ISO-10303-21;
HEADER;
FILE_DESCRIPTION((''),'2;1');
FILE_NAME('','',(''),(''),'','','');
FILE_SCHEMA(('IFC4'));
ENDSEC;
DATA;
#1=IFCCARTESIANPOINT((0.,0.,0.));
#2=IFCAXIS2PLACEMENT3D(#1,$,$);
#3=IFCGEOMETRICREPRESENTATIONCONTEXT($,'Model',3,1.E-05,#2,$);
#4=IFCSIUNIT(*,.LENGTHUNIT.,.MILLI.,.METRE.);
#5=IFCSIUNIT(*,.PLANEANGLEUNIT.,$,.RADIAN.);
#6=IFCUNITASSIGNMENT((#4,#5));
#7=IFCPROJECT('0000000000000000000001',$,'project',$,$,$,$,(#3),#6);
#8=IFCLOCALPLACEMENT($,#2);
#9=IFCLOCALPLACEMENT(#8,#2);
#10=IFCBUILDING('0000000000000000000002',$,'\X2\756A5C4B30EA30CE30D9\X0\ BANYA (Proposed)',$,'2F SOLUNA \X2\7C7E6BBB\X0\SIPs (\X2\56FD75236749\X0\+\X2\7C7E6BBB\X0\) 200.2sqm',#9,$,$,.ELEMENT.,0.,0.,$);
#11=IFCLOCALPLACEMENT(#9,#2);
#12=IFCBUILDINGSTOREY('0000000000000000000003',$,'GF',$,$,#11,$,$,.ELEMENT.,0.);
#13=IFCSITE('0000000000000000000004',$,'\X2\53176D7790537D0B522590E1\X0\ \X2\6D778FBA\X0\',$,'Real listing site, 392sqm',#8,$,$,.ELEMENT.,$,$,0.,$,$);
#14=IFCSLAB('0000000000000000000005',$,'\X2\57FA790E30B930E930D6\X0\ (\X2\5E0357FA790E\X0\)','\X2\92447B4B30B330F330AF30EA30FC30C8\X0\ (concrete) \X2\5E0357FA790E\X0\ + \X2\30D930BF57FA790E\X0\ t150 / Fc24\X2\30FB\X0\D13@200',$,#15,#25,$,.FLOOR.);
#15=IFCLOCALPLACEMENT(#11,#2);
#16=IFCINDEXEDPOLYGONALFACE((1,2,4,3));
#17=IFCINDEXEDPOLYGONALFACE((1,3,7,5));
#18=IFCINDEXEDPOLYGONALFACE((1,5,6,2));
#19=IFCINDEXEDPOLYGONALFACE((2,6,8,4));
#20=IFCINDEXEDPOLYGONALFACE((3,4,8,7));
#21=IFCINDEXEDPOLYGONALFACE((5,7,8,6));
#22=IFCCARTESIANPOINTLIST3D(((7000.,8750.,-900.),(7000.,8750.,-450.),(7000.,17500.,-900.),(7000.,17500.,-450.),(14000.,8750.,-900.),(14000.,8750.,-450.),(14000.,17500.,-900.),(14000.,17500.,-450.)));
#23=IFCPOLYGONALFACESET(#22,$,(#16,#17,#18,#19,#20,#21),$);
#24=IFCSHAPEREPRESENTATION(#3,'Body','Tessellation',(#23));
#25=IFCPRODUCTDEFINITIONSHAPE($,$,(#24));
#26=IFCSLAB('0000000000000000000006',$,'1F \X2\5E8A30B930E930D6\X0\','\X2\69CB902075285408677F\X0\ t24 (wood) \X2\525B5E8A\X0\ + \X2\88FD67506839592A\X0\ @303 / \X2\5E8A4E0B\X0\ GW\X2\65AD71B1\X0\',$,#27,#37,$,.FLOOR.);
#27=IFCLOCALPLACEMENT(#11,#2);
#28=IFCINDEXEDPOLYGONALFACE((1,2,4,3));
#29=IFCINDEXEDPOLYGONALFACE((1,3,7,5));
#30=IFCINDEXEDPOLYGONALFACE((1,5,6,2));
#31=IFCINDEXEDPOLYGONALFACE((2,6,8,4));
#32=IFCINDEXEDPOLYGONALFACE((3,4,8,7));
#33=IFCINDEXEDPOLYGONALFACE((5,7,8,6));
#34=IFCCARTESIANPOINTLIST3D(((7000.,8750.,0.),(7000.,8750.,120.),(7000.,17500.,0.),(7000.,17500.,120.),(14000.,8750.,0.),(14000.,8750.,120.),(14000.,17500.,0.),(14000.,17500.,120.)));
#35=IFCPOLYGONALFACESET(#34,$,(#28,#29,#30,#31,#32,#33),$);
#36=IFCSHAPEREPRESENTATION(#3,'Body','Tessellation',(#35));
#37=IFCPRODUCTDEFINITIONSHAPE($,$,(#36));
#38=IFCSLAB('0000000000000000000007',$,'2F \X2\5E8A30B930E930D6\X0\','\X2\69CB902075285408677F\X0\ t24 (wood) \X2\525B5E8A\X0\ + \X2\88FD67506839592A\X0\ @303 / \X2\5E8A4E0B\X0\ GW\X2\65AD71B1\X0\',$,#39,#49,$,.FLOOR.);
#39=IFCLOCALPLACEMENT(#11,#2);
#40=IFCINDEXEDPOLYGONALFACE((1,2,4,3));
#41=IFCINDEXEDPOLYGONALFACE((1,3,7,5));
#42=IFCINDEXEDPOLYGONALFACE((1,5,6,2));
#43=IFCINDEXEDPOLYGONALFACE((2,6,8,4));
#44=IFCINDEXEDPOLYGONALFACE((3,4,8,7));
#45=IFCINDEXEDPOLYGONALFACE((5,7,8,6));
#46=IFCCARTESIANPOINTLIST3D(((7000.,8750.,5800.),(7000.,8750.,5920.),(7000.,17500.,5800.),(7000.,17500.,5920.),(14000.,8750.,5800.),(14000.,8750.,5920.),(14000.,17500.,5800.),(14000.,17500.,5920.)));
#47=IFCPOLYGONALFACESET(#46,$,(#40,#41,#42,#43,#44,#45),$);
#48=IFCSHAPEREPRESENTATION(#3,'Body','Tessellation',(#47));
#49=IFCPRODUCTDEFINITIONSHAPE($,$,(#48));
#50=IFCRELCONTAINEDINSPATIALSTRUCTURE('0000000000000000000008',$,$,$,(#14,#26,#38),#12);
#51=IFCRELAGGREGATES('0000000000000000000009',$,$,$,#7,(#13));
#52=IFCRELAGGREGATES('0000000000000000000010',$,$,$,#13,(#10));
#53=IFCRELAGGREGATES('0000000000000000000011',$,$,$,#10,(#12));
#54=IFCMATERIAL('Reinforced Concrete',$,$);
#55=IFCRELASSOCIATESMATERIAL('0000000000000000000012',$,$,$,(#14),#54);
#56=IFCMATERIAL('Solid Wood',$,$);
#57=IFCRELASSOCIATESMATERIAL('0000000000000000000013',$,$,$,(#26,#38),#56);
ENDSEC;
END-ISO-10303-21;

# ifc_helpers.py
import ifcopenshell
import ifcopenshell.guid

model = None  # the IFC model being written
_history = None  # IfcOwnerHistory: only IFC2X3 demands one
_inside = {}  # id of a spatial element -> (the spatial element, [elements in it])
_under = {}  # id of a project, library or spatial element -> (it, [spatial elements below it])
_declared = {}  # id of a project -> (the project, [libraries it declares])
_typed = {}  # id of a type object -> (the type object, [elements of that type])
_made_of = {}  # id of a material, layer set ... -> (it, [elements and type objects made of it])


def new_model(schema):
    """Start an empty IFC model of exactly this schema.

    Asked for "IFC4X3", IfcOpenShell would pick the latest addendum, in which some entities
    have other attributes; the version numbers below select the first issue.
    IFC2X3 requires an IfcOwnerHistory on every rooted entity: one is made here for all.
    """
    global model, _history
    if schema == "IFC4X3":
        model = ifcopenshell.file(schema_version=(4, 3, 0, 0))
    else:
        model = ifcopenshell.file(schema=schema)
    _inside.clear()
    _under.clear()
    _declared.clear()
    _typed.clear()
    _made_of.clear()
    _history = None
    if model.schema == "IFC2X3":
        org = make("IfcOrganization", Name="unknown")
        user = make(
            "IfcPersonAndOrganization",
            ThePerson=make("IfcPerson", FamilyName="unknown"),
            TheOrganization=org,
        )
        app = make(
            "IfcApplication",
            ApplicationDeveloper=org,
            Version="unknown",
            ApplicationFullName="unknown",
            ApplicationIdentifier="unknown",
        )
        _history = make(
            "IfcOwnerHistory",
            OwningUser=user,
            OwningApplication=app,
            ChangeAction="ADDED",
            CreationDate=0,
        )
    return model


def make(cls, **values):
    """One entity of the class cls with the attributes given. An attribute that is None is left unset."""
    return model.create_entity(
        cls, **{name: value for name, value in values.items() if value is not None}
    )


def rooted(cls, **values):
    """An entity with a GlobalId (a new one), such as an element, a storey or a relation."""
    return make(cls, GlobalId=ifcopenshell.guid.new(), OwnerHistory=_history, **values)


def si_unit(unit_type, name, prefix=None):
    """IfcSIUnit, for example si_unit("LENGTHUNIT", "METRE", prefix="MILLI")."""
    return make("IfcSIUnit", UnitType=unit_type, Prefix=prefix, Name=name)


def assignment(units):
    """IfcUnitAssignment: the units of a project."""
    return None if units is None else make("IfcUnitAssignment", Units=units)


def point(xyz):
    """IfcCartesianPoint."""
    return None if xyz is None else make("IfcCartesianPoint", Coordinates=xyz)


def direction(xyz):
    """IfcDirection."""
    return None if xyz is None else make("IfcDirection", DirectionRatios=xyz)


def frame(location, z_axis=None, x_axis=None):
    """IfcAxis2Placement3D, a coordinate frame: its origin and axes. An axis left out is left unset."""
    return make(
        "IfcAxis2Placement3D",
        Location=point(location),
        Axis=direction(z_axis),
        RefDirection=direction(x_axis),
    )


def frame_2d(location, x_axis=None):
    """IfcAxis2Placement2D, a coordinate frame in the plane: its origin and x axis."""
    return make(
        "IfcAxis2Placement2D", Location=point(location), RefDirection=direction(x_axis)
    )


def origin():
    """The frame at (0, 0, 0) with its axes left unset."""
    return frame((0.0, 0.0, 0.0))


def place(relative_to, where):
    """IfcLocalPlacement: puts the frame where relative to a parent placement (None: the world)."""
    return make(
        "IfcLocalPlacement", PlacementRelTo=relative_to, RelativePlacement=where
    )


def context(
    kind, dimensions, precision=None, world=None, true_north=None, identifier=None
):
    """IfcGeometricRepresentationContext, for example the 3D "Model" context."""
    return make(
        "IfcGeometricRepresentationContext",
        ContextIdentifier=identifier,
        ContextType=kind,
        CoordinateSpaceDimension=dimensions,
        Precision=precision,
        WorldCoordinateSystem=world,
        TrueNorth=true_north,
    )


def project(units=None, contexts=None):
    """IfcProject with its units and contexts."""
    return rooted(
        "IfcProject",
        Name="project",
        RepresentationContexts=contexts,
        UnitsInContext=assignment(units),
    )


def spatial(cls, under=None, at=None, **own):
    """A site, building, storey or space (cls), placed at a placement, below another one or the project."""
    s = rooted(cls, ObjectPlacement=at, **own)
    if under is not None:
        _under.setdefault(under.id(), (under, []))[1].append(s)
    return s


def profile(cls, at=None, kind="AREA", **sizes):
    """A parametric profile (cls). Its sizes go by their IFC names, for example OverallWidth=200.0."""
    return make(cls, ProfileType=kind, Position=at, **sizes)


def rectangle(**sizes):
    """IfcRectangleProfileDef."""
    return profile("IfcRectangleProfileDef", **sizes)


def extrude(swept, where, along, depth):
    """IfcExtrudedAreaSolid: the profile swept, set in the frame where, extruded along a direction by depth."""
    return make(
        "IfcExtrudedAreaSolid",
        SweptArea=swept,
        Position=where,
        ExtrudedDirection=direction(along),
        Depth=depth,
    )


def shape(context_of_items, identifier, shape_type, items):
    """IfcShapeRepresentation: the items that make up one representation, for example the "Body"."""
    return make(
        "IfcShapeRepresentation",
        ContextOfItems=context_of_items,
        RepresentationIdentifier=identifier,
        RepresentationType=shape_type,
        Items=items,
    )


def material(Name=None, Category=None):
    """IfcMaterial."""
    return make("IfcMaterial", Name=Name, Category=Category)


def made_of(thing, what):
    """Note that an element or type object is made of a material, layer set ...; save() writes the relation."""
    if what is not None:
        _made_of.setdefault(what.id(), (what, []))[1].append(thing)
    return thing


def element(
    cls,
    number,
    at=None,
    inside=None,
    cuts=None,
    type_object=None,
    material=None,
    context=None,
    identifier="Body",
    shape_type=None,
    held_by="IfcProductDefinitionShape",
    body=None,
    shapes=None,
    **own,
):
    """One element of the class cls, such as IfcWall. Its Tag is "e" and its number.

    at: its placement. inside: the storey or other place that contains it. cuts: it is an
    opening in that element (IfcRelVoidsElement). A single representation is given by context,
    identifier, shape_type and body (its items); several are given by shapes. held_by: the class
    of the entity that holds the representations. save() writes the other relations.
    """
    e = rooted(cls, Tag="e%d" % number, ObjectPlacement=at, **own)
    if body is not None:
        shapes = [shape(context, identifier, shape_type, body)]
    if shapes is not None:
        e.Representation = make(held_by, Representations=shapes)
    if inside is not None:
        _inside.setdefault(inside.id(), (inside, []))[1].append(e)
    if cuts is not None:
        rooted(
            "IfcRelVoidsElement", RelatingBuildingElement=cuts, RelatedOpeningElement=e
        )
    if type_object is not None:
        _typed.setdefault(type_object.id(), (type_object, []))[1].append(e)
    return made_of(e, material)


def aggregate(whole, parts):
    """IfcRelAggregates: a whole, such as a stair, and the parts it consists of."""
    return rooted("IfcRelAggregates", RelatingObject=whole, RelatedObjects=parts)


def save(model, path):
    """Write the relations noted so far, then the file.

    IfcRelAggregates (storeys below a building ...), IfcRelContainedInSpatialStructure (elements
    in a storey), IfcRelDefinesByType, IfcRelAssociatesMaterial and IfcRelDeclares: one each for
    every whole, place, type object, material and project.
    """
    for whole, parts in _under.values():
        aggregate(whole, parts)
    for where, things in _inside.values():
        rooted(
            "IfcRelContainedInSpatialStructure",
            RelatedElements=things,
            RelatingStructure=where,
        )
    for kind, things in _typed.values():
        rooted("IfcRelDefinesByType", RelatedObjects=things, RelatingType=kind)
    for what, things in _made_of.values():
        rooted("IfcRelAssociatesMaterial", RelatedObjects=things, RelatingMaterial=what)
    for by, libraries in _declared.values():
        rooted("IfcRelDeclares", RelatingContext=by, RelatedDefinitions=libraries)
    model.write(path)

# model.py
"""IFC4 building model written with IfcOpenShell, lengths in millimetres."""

from ifc_helpers import new_model, si_unit, frame, frame_2d, origin, place, context, project, spatial, rectangle, extrude, material, element, save


model = new_model("IFC4")

# Units and contexts
model_context = context("Model", 3, precision=1e-05, world=origin())
ifc_project = project(units=[si_unit("LENGTHUNIT", "METRE", prefix="MILLI"), si_unit("PLANEANGLEUNIT", "RADIAN")], contexts=[model_context])

# Site, building, storey
site_placement = place(None, origin())
site = spatial("IfcSite", under=ifc_project, at=site_placement, Name="北海道紋別郡 海辺", ObjectType="Real listing site, 392sqm", CompositionType="ELEMENT", RefElevation=0.0)
building_placement = place(site_placement, origin())
building = spatial("IfcBuilding", under=site, at=building_placement, Name="番屋リノベ BANYA (Proposed)", ObjectType="2F SOLUNA 籾殻SIPs (国産杉+籾殻) 200.2sqm", CompositionType="ELEMENT", ElevationOfRefHeight=0.0, ElevationOfTerrain=0.0)
storey_placement = place(building_placement, origin())
storey = spatial("IfcBuildingStorey", under=building, at=storey_placement, Name="GF", CompositionType="ELEMENT", Elevation=0.0)

# Slabs
ifc_material_1 = material(Name="Reinforced Concrete")
slab_1_placement = place(storey_placement, frame((3500.0, 4375.0, -450.0)))
element("IfcSlab", 1, at=slab_1_placement, inside=storey, material=ifc_material_1, Name="基礎スラブ (布基礎)", Description="鉄筋コンクリート (concrete) 布基礎 + ベタ基礎 t150 / Fc24・D13@200", PredefinedType="FLOOR", context=model_context, shape_type="SweptSolid", body=[
    extrude(rectangle(XDim=7000.0, YDim=8750.0, at=frame_2d((3500.0, 4375.0))), frame((3500.0, 4375.0, -450.0)), (0.0, 0.0, 1.0), 450.0),
])
ifc_material_2 = material(Name="Solid Wood")
slab_2_placement = place(storey_placement, frame((3500.0, 4375.0, 0.0)))
element("IfcSlab", 2, at=slab_2_placement, inside=storey, material=ifc_material_2, Name="1F 床スラブ", Description="構造用合板 t24 (wood) 剛床 + 製材根太 @303 / 床下 GW断熱", PredefinedType="FLOOR", context=model_context, shape_type="SweptSolid", body=[
    extrude(rectangle(XDim=7000.0, YDim=8750.0, at=frame_2d((3500.0, 4375.0))), frame((3500.0, 4375.0, 0.0)), (0.0, 0.0, 1.0), 120.0),
])
slab_3_placement = place(storey_placement, frame((3500.0, 4375.0, 2900.0)))
element("IfcSlab", 3, at=slab_3_placement, inside=storey, material=ifc_material_2, Name="2F 床スラブ", Description="構造用合板 t24 (wood) 剛床 + 製材根太 @303 / 床下 GW断熱", PredefinedType="FLOOR", context=model_context, shape_type="SweptSolid", body=[
    extrude(rectangle(XDim=7000.0, YDim=8750.0, at=frame_2d((3500.0, 4375.0))), frame((3500.0, 4375.0, 2900.0)), (0.0, 0.0, 1.0), 120.0),
])

save(model, "model.ifc")
